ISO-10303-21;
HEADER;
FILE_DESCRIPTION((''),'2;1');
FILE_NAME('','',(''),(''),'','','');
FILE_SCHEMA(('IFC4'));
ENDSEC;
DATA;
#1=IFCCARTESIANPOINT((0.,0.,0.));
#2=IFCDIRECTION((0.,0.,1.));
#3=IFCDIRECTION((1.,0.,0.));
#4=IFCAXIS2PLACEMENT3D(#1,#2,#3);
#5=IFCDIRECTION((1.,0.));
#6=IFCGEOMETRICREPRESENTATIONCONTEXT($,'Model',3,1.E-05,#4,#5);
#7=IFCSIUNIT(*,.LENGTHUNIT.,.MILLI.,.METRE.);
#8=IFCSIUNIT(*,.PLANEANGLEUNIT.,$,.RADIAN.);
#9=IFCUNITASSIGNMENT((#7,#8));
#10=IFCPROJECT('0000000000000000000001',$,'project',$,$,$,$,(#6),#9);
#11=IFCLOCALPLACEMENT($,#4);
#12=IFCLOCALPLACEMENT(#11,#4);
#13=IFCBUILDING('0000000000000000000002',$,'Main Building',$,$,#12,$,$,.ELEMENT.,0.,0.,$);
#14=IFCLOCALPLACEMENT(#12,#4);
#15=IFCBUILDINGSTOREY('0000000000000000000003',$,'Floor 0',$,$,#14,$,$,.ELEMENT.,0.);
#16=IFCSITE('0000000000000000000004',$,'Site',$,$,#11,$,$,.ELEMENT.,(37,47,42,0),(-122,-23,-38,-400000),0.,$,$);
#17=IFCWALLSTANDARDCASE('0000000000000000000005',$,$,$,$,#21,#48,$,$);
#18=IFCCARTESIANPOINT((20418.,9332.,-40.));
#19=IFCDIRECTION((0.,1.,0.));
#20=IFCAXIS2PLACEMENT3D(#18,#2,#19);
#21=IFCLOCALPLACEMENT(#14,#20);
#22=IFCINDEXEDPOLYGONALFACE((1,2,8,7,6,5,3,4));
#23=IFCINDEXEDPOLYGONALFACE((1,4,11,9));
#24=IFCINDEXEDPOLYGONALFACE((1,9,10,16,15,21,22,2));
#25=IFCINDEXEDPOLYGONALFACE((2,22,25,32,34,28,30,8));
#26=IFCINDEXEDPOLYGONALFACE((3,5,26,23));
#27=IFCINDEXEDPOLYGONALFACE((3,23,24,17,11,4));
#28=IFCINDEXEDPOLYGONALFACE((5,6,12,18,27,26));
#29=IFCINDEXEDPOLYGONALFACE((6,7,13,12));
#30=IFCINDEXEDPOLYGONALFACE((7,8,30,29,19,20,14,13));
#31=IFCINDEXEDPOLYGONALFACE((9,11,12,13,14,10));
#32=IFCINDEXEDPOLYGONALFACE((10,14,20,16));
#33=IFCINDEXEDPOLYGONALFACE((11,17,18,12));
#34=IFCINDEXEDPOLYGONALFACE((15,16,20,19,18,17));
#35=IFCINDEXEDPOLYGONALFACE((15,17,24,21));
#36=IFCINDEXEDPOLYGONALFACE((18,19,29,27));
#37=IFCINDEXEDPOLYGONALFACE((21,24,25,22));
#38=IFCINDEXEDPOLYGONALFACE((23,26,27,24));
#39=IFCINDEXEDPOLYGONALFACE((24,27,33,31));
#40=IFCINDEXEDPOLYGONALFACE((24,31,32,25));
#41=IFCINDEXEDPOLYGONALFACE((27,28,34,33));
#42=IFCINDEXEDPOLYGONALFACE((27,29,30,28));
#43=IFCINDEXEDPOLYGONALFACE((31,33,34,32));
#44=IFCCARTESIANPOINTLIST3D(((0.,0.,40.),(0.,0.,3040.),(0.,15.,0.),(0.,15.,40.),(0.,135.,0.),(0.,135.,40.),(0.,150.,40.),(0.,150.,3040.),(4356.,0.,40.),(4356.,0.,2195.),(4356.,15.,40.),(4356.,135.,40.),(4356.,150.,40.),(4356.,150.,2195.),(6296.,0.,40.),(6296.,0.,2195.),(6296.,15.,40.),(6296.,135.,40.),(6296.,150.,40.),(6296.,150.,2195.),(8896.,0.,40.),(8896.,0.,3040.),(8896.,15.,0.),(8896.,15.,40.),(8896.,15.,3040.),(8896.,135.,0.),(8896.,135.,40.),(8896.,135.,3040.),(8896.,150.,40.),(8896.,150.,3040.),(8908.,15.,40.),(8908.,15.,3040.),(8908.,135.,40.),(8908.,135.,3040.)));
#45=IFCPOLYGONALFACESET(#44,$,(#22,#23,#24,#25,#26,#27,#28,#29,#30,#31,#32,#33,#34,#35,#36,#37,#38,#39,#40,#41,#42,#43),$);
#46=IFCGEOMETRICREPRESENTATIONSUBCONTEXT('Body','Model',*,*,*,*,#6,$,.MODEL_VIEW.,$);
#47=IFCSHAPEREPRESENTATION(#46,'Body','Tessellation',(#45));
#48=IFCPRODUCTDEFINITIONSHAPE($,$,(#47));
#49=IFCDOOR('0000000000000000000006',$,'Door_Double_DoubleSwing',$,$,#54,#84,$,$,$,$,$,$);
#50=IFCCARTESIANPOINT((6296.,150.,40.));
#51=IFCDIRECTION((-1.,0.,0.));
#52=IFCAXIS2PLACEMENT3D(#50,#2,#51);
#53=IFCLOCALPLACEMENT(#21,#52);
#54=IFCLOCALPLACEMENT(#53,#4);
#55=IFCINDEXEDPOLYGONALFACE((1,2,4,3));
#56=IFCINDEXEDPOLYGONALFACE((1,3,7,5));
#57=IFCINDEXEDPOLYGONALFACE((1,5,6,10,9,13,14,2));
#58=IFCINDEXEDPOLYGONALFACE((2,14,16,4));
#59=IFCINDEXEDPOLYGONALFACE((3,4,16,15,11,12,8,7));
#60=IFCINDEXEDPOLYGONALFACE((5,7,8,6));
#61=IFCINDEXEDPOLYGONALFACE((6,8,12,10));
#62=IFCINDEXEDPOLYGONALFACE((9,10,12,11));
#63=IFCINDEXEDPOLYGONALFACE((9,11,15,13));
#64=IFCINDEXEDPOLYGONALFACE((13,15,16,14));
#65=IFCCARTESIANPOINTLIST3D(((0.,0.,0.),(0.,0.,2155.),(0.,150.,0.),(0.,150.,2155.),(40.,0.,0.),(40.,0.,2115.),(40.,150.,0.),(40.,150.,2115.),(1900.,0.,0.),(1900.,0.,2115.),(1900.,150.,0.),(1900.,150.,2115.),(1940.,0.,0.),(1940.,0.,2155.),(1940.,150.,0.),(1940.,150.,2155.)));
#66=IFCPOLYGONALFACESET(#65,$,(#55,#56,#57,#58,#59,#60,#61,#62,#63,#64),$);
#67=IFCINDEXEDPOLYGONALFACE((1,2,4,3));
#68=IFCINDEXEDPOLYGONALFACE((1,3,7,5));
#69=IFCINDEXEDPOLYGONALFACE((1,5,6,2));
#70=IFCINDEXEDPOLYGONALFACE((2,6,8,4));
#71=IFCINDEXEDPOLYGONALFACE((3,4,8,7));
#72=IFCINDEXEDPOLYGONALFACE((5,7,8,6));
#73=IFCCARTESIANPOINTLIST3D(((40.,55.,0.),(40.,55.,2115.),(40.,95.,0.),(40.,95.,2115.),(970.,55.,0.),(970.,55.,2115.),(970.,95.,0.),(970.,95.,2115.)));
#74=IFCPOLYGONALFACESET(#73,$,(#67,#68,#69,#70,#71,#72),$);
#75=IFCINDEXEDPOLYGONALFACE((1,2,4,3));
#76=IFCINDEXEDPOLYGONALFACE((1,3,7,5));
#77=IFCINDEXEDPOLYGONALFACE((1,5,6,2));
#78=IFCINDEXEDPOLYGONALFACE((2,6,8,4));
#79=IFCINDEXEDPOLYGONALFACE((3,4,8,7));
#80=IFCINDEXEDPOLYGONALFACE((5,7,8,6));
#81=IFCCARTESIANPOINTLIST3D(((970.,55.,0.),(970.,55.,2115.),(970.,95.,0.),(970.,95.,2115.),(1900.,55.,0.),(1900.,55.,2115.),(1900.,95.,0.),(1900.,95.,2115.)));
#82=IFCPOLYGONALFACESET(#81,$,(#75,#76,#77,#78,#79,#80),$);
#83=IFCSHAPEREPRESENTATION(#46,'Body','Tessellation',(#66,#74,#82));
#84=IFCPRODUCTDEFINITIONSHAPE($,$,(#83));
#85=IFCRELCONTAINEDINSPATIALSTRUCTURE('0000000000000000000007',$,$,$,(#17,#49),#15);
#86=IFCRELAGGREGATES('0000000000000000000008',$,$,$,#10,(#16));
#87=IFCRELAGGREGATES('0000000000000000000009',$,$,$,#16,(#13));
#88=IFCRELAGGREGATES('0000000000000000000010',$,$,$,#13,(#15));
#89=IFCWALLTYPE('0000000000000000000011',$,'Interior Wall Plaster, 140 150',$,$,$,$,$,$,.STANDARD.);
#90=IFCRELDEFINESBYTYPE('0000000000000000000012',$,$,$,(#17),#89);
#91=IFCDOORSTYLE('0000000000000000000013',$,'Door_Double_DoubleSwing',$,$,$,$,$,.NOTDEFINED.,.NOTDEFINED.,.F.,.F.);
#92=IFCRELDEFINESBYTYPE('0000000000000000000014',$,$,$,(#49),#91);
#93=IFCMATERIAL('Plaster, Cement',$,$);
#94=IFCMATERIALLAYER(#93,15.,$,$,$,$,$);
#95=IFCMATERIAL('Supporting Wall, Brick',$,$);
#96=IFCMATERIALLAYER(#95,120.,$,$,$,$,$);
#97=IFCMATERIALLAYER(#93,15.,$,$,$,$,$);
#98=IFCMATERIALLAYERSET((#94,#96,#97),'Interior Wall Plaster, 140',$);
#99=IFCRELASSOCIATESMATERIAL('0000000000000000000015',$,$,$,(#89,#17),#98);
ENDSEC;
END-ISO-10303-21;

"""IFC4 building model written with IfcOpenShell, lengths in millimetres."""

from ifc_helpers import new_model, si_unit, direction, frame, frame_2d, origin_with_axes, place, context, subcontext, project, spatial, polyline, rectangle, outline, extrude, clip, bounded_halfspace, source, transform, mapped, material, layer, layer_set, layer_usage, type_object, type_shapes, element, fill, save


model = new_model("IFC4")

# Units and contexts
model_context = context("Model", 3, precision=1e-05, world=origin_with_axes(), true_north=direction((1.0, 0.0)))
body_context = subcontext(model_context, "Body", "Model", "MODEL_VIEW")
ifc_project = project(units=[si_unit("LENGTHUNIT", "METRE", prefix="MILLI"), si_unit("PLANEANGLEUNIT", "RADIAN")], contexts=[model_context])

# Site, building, storey
site_placement = place(None, origin_with_axes())
site = spatial("IfcSite", under=ifc_project, at=site_placement, Name="Site", CompositionType="ELEMENT", RefLatitude=(37, 47, 42, 0), RefLongitude=(-122, -23, -38, -400000), RefElevation=0.0)
building_placement = place(site_placement, origin_with_axes())
building = spatial("IfcBuilding", under=site, at=building_placement, Name="Main Building", CompositionType="ELEMENT", ElevationOfRefHeight=0.0, ElevationOfTerrain=0.0)
storey_placement = place(building_placement, origin_with_axes())
storey = spatial("IfcBuildingStorey", under=building, at=storey_placement, Name="Floor 0", CompositionType="ELEMENT", Elevation=0.0)

# Shared definitions
ifc_material_1 = material(Name="Supporting Wall, Brick")

# Wall, opening, door
ifc_material_2 = material(Name="Plaster, Cement")
ifc_layer_1 = layer(ifc_material_2, 15.0)
ifc_layer_2 = layer(ifc_material_1, 120.0)
ifc_layer_3 = layer(ifc_material_2, 15.0)
ifc_layer_set_1 = layer_set([ifc_layer_1, ifc_layer_2, ifc_layer_3], Name="Interior Wall Plaster, 140")
ifc_layer_usage_1 = layer_usage(ifc_layer_set_1, "AXIS2", "POSITIVE", 0.0)
wall_type_1 = type_object("IfcWallType", Name="Interior Wall Plaster, 140 150", PredefinedType="STANDARD", material=ifc_layer_set_1)
wall_1_placement = place(storey_placement, frame((20418.0, 9332.0, -40.0), z_axis=(0.0, 0.0, 1.0), x_axis=(0.0, 1.0, 0.0)))
wall_1 = element("IfcWallStandardCase", 1, at=wall_1_placement, inside=storey, type_object=wall_type_1, material=ifc_layer_usage_1, context=body_context, shape_type="Clipping", body=[
    clip(clip(clip(extrude(outline(polyline([(2221.0, 75.0), (2221.0, 60.0), (2233.0, 60.0), (2233.0, -60.0), (2221.0, -60.0), (2221.0, -75.0), (-6675.0, -75.0), (-6675.0, 75.0), (2221.0, 75.0)])), frame((6675.0, 75.0, 0.0), z_axis=(0.0, 0.0, 1.0), x_axis=(1.0, 0.0, 0.0)), (0.0, 0.0, 1.0), 3040.0), bounded_halfspace(frame((-9332.0, 20418.0, 40.0), z_axis=(0.0, 0.0, -1.0), x_axis=(0.0, 1.0, 0.0)), False, frame((6675.0, 75.0, 0.0), z_axis=(0.0, 0.0, 1.0), x_axis=(1.0, 0.0, 0.0)), polyline([(2221.0, 60.0), (-6675.0, 60.0), (-6675.0, 75.0), (2221.0, 75.0), (2221.0, 60.0)]))), bounded_halfspace(frame((-9332.0, 20418.0, 40.0), z_axis=(0.0, 0.0, -1.0), x_axis=(0.0, 1.0, 0.0)), False, frame((6675.0, 75.0, 0.0), z_axis=(0.0, 0.0, 1.0), x_axis=(1.0, 0.0, 0.0)), polyline([(-6675.0, -60.0), (2221.0, -60.0), (2221.0, -75.0), (-6675.0, -75.0), (-6675.0, -60.0)]))), bounded_halfspace(frame((-9332.0, 20418.0, 40.0), z_axis=(0.0, 0.0, -1.0), x_axis=(0.0, 1.0, 0.0)), False, frame((6675.0, 75.0, 0.0), z_axis=(0.0, 0.0, 1.0), x_axis=(1.0, 0.0, 0.0)), polyline([(2221.0, -60.0), (2221.0, 60.0), (2233.0, 60.0), (2233.0, -60.0), (2221.0, -60.0)]))),
])
opening_1_placement = place(wall_1_placement, frame((6296.0, 150.0, 40.0), z_axis=(0.0, 0.0, 1.0), x_axis=(-1.0, 0.0, 0.0)))
opening_1 = element("IfcOpeningElement", 2, at=opening_1_placement, cuts=wall_1, ObjectType="Opening", context=body_context, shape_type="SweptSolid", body=[
    extrude(outline(polyline([(970.0, 1077.5), (970.0, -1077.5), (-970.0, -1077.5), (-970.0, 1077.5), (970.0, 1077.5)])), frame((970.0, 0.0, 1077.5), z_axis=(0.0, 1.0, 0.0), x_axis=(1.0, 0.0, 0.0)), (0.0, 0.0, 1.0), 1000.0),
])
door_style_1 = type_object("IfcDoorStyle", Name="Door_Double_DoubleSwing", ConstructionType="NOTDEFINED", OperationType="NOTDEFINED", ParameterTakesPrecedence=False, Sizeable=False)
shared_shape_1 = source(origin_with_axes(), body_context, "Body", "SweptSolid", [
    extrude(outline(polyline([(970.0, -1067.5), (930.0, -1067.5), (930.0, 1047.5), (-930.0, 1047.5), (-930.0, -1067.5), (-970.0, -1067.5), (-970.0, 1087.5), (970.0, 1087.5), (970.0, -1067.5)])), frame((970.0, 1067.5, -150.0), z_axis=(0.0, 0.0, 1.0), x_axis=(1.0, 0.0, 0.0)), (0.0, 0.0, 1.0), 150.0),
    extrude(rectangle(XDim=2115.0, YDim=930.0, at=frame_2d((0.0, 0.0), x_axis=(0.0, 1.0))), frame((505.0, 1057.5, -95.0), z_axis=(0.0, 0.0, 1.0), x_axis=(1.0, 0.0, 0.0)), (0.0, 0.0, 1.0), 40.0),
    extrude(rectangle(XDim=2115.0, YDim=930.0, at=frame_2d((0.0, 0.0), x_axis=(0.0, 1.0))), frame((1435.0, 1057.5, -95.0), z_axis=(0.0, 0.0, 1.0), x_axis=(1.0, 0.0, 0.0)), (0.0, 0.0, 1.0), 40.0),
])
type_shapes(door_style_1, [shared_shape_1])
door_1_placement = place(opening_1_placement, origin_with_axes())
door_1 = element("IfcDoor", 3, at=door_1_placement, inside=storey, type_object=door_style_1, Name="Door_Double_DoubleSwing", context=body_context, shape_type="MappedRepresentation", body=[
    mapped(shared_shape_1, transform((0.0, 0.0, 0.0), x_axis=(1.0, 0.0, 0.0), y_axis=(0.0, 0.0, 1.0), z_axis=(0.0, -1.0, 0.0), scale=1.0)),
])
fill(opening_1, door_1)

save(model, "model.ifc")
